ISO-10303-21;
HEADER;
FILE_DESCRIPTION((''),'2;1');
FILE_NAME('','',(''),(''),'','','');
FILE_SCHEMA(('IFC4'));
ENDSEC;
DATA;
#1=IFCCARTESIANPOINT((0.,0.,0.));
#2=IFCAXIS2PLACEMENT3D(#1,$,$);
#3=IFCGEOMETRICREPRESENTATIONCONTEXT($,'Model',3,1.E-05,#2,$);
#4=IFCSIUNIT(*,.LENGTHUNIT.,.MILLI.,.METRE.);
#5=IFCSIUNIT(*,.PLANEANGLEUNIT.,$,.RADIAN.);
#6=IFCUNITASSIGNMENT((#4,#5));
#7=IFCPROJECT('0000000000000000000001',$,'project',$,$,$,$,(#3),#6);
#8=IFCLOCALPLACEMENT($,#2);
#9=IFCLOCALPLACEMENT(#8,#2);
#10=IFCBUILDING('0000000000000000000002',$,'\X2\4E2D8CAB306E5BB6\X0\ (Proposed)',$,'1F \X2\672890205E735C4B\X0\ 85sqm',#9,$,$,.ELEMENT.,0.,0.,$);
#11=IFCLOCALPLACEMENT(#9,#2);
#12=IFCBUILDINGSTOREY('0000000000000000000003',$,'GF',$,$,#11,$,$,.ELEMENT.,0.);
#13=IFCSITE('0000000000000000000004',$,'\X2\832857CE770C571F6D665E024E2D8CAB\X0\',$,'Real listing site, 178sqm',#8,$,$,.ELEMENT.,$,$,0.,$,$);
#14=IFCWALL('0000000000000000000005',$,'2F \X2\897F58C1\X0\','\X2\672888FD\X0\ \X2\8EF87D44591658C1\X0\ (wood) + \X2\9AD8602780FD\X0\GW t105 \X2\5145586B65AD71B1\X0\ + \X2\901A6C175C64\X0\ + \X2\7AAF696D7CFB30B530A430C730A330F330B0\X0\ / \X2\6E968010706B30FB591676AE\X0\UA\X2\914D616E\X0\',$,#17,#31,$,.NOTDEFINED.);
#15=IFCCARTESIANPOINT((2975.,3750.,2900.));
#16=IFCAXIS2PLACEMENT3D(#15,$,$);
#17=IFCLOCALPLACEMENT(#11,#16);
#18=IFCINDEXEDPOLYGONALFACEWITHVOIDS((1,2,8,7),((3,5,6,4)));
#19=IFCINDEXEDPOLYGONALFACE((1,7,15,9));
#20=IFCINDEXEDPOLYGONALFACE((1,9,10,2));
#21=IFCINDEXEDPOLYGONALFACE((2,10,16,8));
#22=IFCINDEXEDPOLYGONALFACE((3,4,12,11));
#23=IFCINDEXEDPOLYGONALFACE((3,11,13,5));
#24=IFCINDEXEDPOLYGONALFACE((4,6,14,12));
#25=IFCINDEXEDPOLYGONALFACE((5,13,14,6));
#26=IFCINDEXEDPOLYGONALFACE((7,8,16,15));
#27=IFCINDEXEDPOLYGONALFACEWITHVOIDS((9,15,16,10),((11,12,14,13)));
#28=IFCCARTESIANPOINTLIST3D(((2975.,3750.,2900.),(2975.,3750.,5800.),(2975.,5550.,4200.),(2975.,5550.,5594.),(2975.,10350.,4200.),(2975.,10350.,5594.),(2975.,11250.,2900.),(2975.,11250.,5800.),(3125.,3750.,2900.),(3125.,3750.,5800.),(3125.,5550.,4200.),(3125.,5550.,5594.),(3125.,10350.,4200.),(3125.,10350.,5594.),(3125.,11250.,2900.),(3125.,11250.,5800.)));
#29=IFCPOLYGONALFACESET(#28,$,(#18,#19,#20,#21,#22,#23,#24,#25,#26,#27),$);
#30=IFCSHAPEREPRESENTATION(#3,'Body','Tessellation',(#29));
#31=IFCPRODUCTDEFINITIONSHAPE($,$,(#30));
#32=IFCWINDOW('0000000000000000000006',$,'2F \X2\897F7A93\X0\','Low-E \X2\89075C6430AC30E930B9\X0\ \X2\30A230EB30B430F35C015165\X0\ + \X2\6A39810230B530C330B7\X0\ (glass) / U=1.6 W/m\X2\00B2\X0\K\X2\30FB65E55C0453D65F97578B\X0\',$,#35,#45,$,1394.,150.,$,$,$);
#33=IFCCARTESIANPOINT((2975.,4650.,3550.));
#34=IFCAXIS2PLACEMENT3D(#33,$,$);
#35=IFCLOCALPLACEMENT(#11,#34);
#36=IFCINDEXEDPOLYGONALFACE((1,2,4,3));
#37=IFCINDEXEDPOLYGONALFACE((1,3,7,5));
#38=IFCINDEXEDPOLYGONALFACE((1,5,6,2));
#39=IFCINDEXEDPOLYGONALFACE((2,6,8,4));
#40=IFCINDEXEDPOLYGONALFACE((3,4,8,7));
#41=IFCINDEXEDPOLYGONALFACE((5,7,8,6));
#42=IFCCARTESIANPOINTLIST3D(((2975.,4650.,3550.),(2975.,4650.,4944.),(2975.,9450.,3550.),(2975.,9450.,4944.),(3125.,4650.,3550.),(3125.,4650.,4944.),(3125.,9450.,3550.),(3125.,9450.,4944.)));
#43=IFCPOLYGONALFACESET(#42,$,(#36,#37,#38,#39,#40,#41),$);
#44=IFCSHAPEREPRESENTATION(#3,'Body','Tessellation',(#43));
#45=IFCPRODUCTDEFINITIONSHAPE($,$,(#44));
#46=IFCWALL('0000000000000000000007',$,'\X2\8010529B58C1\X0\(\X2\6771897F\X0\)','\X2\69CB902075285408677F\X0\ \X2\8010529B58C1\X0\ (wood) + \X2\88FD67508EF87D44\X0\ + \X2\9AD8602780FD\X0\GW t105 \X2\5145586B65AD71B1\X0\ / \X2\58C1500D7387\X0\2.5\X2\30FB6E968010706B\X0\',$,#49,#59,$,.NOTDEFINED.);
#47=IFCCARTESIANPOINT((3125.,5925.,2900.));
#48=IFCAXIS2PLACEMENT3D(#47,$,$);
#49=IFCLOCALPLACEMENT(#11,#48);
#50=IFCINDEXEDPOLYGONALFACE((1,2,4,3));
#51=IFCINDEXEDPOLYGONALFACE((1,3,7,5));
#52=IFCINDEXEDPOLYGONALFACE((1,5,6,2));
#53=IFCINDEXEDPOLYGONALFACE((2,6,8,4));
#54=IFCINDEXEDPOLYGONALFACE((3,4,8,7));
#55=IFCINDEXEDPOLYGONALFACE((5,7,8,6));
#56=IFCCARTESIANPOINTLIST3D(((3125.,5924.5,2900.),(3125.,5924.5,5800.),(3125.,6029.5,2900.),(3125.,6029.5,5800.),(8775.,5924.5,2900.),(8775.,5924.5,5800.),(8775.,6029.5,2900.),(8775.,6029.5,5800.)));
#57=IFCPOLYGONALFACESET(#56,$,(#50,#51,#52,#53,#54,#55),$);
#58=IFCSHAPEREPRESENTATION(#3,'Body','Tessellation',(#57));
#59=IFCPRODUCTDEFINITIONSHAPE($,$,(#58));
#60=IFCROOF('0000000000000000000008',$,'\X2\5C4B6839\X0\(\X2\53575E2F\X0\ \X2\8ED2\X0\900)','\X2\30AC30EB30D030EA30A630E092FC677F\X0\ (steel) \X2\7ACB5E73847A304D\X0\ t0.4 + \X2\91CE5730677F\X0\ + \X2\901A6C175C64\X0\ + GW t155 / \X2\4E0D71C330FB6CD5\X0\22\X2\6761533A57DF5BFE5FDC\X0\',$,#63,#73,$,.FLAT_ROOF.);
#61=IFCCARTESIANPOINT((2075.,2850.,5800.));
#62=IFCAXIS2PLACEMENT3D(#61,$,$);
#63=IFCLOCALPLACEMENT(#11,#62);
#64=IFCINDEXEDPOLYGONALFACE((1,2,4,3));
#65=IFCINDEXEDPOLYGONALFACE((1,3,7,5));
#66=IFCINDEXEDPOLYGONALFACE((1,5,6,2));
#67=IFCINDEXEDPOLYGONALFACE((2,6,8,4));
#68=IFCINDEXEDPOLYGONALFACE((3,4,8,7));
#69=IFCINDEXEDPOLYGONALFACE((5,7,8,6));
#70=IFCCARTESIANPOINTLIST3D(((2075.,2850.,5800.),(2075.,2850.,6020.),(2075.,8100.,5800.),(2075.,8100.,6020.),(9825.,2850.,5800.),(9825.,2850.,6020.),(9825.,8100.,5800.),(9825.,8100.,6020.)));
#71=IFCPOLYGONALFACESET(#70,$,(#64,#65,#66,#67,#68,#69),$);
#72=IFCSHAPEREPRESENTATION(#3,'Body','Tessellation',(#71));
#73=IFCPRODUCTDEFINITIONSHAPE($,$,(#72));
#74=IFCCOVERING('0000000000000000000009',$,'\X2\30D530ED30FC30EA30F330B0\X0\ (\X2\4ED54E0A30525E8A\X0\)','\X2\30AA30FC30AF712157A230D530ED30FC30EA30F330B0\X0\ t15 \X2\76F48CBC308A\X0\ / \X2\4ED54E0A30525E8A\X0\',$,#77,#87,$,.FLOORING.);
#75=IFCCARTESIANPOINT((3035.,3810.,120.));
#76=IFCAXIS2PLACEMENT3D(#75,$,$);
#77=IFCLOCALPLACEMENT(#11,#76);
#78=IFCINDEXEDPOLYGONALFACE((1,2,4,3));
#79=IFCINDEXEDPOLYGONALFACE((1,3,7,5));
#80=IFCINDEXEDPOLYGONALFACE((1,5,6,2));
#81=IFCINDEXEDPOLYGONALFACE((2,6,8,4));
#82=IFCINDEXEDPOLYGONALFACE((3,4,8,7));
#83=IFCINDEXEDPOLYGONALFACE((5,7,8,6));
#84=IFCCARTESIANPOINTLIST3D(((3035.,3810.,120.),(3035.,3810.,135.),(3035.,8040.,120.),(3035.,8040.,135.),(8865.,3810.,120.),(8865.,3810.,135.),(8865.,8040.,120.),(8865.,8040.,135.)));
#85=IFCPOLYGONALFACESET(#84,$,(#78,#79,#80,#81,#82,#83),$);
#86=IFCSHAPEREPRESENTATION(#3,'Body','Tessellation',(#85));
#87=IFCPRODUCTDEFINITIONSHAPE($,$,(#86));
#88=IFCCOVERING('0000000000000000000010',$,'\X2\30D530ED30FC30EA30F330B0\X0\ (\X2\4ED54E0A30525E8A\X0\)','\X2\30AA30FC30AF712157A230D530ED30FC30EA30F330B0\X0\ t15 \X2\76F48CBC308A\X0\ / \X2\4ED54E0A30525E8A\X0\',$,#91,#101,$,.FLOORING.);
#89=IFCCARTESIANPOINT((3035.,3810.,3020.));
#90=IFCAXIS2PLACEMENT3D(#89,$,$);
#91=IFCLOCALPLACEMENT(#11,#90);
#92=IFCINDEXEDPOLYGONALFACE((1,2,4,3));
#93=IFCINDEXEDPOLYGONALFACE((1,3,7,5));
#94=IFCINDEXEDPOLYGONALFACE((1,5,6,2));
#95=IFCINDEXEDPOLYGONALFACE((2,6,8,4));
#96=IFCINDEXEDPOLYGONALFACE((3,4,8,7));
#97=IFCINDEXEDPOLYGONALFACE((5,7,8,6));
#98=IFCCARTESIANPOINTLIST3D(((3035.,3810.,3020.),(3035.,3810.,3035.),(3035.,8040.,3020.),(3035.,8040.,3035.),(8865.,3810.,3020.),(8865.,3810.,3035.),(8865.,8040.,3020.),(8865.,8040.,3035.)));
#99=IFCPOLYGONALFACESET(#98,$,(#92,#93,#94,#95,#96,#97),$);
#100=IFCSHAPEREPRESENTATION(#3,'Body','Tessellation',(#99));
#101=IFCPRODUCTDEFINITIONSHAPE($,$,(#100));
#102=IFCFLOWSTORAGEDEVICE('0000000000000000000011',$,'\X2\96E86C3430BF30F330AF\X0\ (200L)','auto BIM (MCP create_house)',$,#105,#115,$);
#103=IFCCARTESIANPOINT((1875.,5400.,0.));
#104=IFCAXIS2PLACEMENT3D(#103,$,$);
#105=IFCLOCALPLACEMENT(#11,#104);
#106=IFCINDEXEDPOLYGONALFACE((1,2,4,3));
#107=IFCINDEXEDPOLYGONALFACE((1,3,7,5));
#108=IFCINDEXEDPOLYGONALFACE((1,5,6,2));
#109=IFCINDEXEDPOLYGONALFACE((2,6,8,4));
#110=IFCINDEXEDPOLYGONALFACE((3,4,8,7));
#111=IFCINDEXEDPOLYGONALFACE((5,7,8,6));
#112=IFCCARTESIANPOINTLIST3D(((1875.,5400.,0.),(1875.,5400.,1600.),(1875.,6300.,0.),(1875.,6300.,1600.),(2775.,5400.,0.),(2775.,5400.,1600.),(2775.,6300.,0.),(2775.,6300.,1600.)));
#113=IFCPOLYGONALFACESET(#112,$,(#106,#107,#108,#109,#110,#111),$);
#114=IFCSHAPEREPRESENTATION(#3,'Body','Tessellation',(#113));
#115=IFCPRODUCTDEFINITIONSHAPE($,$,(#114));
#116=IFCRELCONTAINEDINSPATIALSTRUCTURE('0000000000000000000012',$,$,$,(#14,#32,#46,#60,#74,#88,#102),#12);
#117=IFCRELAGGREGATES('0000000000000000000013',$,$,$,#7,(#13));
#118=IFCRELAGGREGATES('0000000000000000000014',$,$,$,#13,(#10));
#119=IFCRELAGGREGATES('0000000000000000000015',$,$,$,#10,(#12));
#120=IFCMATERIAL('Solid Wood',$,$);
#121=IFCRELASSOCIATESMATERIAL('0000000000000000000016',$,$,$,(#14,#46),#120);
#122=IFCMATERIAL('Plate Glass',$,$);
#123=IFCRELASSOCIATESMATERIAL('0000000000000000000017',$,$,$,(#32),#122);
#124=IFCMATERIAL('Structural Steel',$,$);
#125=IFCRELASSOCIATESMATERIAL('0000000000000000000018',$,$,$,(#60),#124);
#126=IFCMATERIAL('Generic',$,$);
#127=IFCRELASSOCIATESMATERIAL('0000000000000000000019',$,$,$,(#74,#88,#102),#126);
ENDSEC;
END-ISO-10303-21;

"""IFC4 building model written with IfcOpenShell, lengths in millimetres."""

from ifc_helpers import new_model, si_unit, frame, frame_2d, origin, place, context, project, spatial, rectangle, extrude, material, element, fill, save


model = new_model("IFC4")

# Units and contexts
model_context = context("Model", 3, precision=1e-05, world=origin())
ifc_project = project(units=[si_unit("LENGTHUNIT", "METRE", prefix="MILLI"), si_unit("PLANEANGLEUNIT", "RADIAN")], contexts=[model_context])

# Site, building, storey
site_placement = place(None, origin())
site = spatial("IfcSite", under=ifc_project, at=site_placement, Name="茨城県土浦市中貫", ObjectType="Real listing site, 178sqm", CompositionType="ELEMENT", RefElevation=0.0)
building_placement = place(site_placement, origin())
building = spatial("IfcBuilding", under=site, at=building_placement, Name="中貫の家 (Proposed)", ObjectType="1F 木造平屋 85sqm", CompositionType="ELEMENT", ElevationOfRefHeight=0.0, ElevationOfTerrain=0.0)
storey_placement = place(building_placement, origin())
storey = spatial("IfcBuildingStorey", under=building, at=storey_placement, Name="GF", CompositionType="ELEMENT", Elevation=0.0)

# Shared definitions
ifc_material_1 = material(Name="Solid Wood")
ifc_material_2 = material(Name="Generic")

# Shared definitions
ifc_material_3 = material(Name="Plate Glass")

# Wall, opening, window
wall_1_placement = place(storey_placement, frame((2975.0, 3750.0, 2900.0)))
wall_1 = element("IfcWall", 1, at=wall_1_placement, inside=storey, material=ifc_material_1, Name="2F 西壁", Description="木製 軸組外壁 (wood) + 高性能GW t105 充填断熱 + 通気層 + 窯業系サイディング / 準耐火・外皮UA配慮", PredefinedType="NOTDEFINED", context=model_context, shape_type="SweptSolid", body=[
    extrude(rectangle(XDim=150.0, YDim=7500.0, at=frame_2d((75.0, 3750.0))), frame((2975.0, 3750.0, 2900.0)), (0.0, 0.0, 1.0), 2900.0),
])
opening_1_placement = place(storey_placement, frame((2975.0, 4650.0, 3550.0)))
opening_1 = element("IfcOpeningElement", 2, at=opening_1_placement, cuts=wall_1, PredefinedType="NOTDEFINED", context=model_context, shape_type="SweptSolid", body=[
    extrude(rectangle(XDim=150.0, YDim=4800.0, at=frame_2d((75.0, 2400.0))), frame((2975.0, 4650.0, 3550.0)), (0.0, 0.0, 1.0), 1394.0),
])
window_1_placement = place(storey_placement, frame((2975.0, 4650.0, 3550.0)))
window_1 = element("IfcWindow", 3, at=window_1_placement, inside=storey, material=ifc_material_3, Name="2F 西窓", Description="Low-E 複層ガラス アルゴン封入 + 樹脂サッシ (glass) / U=1.6 W/m²K・日射取得型", OverallHeight=1394.0, OverallWidth=150.0, context=model_context, shape_type="SweptSolid", body=[
    extrude(rectangle(XDim=150.0, YDim=4800.0, at=frame_2d((75.0, 2400.0))), frame((2975.0, 4650.0, 3550.0)), (0.0, 0.0, 1.0), 1394.0),
])
fill(opening_1, window_1)

# Wall
wall_2_placement = place(storey_placement, frame((3125.0, 5925.0, 2900.0)))
element("IfcWall", 4, at=wall_2_placement, inside=storey, material=ifc_material_1, Name="耐力壁(東西)", Description="構造用合板 耐力壁 (wood) + 製材軸組 + 高性能GW t105 充填断熱 / 壁倍率2.5・準耐火", PredefinedType="NOTDEFINED", context=model_context, shape_type="SweptSolid", body=[
    extrude(rectangle(XDim=5650.0, YDim=105.0, at=frame_2d((2825.0, 52.0))), frame((3125.0, 5925.0, 2900.0)), (0.0, 0.0, 1.0), 2900.0),
])

# Roof
ifc_material_4 = material(Name="Structural Steel")
for number, where, name in (
    (5, (2075.0, 2850.0, 5800.0), "屋根(南帯 軒900)"),
):
    element("IfcRoof", number, at=place(storey_placement, frame(where)), inside=storey, material=ifc_material_4, Name=name, Description="ガルバリウム鋼板 (steel) 立平葺き t0.4 + 野地板 + 通気層 + GW t155 / 不燃・法22条区域対応", PredefinedType="FLAT_ROOF", context=model_context, shape_type="SweptSolid", body=[
        extrude(rectangle(XDim=7750.0, YDim=5250.0, at=frame_2d((3875.0, 2625.0))), frame((2075.0, 2850.0, 5800.0)), (0.0, 0.0, 1.0), 220.0),
    ])

# Coverings
covering_1_placement = place(storey_placement, frame((3035.0, 3810.0, 120.0)))
element("IfcCovering", 6, at=covering_1_placement, inside=storey, material=ifc_material_2, Name="フローリング (仕上げ床)", Description="オーク無垢フローリング t15 直貼り / 仕上げ床", PredefinedType="FLOORING", context=model_context, shape_type="SweptSolid", body=[
    extrude(rectangle(XDim=5830.0, YDim=4230.0, at=frame_2d((2915.0, 2115.0))), frame((3035.0, 3810.0, 120.0)), (0.0, 0.0, 1.0), 15.0),
])
covering_2_placement = place(storey_placement, frame((3035.0, 3810.0, 3020.0)))
element("IfcCovering", 7, at=covering_2_placement, inside=storey, material=ifc_material_2, Name="フローリング (仕上げ床)", Description="オーク無垢フローリング t15 直貼り / 仕上げ床", PredefinedType="FLOORING", context=model_context, shape_type="SweptSolid", body=[
    extrude(rectangle(XDim=5830.0, YDim=4230.0, at=frame_2d((2915.0, 2115.0))), frame((3035.0, 3810.0, 3020.0)), (0.0, 0.0, 1.0), 15.0),
])

# Flow storage device
flow_storage_device_placement = place(storey_placement, frame((1875.0, 5400.0, 0.0)))
element("IfcFlowStorageDevice", 8, at=flow_storage_device_placement, inside=storey, material=ifc_material_2, Name="雨水タンク (200L)", Description="auto BIM (MCP create_house)", context=model_context, shape_type="SweptSolid", body=[
    extrude(rectangle(XDim=900.0, YDim=900.0, at=frame_2d((450.0, 450.0))), frame((1875.0, 5400.0, 0.0)), (0.0, 0.0, 1.0), 1600.0),
])

save(model, "model.ifc")
